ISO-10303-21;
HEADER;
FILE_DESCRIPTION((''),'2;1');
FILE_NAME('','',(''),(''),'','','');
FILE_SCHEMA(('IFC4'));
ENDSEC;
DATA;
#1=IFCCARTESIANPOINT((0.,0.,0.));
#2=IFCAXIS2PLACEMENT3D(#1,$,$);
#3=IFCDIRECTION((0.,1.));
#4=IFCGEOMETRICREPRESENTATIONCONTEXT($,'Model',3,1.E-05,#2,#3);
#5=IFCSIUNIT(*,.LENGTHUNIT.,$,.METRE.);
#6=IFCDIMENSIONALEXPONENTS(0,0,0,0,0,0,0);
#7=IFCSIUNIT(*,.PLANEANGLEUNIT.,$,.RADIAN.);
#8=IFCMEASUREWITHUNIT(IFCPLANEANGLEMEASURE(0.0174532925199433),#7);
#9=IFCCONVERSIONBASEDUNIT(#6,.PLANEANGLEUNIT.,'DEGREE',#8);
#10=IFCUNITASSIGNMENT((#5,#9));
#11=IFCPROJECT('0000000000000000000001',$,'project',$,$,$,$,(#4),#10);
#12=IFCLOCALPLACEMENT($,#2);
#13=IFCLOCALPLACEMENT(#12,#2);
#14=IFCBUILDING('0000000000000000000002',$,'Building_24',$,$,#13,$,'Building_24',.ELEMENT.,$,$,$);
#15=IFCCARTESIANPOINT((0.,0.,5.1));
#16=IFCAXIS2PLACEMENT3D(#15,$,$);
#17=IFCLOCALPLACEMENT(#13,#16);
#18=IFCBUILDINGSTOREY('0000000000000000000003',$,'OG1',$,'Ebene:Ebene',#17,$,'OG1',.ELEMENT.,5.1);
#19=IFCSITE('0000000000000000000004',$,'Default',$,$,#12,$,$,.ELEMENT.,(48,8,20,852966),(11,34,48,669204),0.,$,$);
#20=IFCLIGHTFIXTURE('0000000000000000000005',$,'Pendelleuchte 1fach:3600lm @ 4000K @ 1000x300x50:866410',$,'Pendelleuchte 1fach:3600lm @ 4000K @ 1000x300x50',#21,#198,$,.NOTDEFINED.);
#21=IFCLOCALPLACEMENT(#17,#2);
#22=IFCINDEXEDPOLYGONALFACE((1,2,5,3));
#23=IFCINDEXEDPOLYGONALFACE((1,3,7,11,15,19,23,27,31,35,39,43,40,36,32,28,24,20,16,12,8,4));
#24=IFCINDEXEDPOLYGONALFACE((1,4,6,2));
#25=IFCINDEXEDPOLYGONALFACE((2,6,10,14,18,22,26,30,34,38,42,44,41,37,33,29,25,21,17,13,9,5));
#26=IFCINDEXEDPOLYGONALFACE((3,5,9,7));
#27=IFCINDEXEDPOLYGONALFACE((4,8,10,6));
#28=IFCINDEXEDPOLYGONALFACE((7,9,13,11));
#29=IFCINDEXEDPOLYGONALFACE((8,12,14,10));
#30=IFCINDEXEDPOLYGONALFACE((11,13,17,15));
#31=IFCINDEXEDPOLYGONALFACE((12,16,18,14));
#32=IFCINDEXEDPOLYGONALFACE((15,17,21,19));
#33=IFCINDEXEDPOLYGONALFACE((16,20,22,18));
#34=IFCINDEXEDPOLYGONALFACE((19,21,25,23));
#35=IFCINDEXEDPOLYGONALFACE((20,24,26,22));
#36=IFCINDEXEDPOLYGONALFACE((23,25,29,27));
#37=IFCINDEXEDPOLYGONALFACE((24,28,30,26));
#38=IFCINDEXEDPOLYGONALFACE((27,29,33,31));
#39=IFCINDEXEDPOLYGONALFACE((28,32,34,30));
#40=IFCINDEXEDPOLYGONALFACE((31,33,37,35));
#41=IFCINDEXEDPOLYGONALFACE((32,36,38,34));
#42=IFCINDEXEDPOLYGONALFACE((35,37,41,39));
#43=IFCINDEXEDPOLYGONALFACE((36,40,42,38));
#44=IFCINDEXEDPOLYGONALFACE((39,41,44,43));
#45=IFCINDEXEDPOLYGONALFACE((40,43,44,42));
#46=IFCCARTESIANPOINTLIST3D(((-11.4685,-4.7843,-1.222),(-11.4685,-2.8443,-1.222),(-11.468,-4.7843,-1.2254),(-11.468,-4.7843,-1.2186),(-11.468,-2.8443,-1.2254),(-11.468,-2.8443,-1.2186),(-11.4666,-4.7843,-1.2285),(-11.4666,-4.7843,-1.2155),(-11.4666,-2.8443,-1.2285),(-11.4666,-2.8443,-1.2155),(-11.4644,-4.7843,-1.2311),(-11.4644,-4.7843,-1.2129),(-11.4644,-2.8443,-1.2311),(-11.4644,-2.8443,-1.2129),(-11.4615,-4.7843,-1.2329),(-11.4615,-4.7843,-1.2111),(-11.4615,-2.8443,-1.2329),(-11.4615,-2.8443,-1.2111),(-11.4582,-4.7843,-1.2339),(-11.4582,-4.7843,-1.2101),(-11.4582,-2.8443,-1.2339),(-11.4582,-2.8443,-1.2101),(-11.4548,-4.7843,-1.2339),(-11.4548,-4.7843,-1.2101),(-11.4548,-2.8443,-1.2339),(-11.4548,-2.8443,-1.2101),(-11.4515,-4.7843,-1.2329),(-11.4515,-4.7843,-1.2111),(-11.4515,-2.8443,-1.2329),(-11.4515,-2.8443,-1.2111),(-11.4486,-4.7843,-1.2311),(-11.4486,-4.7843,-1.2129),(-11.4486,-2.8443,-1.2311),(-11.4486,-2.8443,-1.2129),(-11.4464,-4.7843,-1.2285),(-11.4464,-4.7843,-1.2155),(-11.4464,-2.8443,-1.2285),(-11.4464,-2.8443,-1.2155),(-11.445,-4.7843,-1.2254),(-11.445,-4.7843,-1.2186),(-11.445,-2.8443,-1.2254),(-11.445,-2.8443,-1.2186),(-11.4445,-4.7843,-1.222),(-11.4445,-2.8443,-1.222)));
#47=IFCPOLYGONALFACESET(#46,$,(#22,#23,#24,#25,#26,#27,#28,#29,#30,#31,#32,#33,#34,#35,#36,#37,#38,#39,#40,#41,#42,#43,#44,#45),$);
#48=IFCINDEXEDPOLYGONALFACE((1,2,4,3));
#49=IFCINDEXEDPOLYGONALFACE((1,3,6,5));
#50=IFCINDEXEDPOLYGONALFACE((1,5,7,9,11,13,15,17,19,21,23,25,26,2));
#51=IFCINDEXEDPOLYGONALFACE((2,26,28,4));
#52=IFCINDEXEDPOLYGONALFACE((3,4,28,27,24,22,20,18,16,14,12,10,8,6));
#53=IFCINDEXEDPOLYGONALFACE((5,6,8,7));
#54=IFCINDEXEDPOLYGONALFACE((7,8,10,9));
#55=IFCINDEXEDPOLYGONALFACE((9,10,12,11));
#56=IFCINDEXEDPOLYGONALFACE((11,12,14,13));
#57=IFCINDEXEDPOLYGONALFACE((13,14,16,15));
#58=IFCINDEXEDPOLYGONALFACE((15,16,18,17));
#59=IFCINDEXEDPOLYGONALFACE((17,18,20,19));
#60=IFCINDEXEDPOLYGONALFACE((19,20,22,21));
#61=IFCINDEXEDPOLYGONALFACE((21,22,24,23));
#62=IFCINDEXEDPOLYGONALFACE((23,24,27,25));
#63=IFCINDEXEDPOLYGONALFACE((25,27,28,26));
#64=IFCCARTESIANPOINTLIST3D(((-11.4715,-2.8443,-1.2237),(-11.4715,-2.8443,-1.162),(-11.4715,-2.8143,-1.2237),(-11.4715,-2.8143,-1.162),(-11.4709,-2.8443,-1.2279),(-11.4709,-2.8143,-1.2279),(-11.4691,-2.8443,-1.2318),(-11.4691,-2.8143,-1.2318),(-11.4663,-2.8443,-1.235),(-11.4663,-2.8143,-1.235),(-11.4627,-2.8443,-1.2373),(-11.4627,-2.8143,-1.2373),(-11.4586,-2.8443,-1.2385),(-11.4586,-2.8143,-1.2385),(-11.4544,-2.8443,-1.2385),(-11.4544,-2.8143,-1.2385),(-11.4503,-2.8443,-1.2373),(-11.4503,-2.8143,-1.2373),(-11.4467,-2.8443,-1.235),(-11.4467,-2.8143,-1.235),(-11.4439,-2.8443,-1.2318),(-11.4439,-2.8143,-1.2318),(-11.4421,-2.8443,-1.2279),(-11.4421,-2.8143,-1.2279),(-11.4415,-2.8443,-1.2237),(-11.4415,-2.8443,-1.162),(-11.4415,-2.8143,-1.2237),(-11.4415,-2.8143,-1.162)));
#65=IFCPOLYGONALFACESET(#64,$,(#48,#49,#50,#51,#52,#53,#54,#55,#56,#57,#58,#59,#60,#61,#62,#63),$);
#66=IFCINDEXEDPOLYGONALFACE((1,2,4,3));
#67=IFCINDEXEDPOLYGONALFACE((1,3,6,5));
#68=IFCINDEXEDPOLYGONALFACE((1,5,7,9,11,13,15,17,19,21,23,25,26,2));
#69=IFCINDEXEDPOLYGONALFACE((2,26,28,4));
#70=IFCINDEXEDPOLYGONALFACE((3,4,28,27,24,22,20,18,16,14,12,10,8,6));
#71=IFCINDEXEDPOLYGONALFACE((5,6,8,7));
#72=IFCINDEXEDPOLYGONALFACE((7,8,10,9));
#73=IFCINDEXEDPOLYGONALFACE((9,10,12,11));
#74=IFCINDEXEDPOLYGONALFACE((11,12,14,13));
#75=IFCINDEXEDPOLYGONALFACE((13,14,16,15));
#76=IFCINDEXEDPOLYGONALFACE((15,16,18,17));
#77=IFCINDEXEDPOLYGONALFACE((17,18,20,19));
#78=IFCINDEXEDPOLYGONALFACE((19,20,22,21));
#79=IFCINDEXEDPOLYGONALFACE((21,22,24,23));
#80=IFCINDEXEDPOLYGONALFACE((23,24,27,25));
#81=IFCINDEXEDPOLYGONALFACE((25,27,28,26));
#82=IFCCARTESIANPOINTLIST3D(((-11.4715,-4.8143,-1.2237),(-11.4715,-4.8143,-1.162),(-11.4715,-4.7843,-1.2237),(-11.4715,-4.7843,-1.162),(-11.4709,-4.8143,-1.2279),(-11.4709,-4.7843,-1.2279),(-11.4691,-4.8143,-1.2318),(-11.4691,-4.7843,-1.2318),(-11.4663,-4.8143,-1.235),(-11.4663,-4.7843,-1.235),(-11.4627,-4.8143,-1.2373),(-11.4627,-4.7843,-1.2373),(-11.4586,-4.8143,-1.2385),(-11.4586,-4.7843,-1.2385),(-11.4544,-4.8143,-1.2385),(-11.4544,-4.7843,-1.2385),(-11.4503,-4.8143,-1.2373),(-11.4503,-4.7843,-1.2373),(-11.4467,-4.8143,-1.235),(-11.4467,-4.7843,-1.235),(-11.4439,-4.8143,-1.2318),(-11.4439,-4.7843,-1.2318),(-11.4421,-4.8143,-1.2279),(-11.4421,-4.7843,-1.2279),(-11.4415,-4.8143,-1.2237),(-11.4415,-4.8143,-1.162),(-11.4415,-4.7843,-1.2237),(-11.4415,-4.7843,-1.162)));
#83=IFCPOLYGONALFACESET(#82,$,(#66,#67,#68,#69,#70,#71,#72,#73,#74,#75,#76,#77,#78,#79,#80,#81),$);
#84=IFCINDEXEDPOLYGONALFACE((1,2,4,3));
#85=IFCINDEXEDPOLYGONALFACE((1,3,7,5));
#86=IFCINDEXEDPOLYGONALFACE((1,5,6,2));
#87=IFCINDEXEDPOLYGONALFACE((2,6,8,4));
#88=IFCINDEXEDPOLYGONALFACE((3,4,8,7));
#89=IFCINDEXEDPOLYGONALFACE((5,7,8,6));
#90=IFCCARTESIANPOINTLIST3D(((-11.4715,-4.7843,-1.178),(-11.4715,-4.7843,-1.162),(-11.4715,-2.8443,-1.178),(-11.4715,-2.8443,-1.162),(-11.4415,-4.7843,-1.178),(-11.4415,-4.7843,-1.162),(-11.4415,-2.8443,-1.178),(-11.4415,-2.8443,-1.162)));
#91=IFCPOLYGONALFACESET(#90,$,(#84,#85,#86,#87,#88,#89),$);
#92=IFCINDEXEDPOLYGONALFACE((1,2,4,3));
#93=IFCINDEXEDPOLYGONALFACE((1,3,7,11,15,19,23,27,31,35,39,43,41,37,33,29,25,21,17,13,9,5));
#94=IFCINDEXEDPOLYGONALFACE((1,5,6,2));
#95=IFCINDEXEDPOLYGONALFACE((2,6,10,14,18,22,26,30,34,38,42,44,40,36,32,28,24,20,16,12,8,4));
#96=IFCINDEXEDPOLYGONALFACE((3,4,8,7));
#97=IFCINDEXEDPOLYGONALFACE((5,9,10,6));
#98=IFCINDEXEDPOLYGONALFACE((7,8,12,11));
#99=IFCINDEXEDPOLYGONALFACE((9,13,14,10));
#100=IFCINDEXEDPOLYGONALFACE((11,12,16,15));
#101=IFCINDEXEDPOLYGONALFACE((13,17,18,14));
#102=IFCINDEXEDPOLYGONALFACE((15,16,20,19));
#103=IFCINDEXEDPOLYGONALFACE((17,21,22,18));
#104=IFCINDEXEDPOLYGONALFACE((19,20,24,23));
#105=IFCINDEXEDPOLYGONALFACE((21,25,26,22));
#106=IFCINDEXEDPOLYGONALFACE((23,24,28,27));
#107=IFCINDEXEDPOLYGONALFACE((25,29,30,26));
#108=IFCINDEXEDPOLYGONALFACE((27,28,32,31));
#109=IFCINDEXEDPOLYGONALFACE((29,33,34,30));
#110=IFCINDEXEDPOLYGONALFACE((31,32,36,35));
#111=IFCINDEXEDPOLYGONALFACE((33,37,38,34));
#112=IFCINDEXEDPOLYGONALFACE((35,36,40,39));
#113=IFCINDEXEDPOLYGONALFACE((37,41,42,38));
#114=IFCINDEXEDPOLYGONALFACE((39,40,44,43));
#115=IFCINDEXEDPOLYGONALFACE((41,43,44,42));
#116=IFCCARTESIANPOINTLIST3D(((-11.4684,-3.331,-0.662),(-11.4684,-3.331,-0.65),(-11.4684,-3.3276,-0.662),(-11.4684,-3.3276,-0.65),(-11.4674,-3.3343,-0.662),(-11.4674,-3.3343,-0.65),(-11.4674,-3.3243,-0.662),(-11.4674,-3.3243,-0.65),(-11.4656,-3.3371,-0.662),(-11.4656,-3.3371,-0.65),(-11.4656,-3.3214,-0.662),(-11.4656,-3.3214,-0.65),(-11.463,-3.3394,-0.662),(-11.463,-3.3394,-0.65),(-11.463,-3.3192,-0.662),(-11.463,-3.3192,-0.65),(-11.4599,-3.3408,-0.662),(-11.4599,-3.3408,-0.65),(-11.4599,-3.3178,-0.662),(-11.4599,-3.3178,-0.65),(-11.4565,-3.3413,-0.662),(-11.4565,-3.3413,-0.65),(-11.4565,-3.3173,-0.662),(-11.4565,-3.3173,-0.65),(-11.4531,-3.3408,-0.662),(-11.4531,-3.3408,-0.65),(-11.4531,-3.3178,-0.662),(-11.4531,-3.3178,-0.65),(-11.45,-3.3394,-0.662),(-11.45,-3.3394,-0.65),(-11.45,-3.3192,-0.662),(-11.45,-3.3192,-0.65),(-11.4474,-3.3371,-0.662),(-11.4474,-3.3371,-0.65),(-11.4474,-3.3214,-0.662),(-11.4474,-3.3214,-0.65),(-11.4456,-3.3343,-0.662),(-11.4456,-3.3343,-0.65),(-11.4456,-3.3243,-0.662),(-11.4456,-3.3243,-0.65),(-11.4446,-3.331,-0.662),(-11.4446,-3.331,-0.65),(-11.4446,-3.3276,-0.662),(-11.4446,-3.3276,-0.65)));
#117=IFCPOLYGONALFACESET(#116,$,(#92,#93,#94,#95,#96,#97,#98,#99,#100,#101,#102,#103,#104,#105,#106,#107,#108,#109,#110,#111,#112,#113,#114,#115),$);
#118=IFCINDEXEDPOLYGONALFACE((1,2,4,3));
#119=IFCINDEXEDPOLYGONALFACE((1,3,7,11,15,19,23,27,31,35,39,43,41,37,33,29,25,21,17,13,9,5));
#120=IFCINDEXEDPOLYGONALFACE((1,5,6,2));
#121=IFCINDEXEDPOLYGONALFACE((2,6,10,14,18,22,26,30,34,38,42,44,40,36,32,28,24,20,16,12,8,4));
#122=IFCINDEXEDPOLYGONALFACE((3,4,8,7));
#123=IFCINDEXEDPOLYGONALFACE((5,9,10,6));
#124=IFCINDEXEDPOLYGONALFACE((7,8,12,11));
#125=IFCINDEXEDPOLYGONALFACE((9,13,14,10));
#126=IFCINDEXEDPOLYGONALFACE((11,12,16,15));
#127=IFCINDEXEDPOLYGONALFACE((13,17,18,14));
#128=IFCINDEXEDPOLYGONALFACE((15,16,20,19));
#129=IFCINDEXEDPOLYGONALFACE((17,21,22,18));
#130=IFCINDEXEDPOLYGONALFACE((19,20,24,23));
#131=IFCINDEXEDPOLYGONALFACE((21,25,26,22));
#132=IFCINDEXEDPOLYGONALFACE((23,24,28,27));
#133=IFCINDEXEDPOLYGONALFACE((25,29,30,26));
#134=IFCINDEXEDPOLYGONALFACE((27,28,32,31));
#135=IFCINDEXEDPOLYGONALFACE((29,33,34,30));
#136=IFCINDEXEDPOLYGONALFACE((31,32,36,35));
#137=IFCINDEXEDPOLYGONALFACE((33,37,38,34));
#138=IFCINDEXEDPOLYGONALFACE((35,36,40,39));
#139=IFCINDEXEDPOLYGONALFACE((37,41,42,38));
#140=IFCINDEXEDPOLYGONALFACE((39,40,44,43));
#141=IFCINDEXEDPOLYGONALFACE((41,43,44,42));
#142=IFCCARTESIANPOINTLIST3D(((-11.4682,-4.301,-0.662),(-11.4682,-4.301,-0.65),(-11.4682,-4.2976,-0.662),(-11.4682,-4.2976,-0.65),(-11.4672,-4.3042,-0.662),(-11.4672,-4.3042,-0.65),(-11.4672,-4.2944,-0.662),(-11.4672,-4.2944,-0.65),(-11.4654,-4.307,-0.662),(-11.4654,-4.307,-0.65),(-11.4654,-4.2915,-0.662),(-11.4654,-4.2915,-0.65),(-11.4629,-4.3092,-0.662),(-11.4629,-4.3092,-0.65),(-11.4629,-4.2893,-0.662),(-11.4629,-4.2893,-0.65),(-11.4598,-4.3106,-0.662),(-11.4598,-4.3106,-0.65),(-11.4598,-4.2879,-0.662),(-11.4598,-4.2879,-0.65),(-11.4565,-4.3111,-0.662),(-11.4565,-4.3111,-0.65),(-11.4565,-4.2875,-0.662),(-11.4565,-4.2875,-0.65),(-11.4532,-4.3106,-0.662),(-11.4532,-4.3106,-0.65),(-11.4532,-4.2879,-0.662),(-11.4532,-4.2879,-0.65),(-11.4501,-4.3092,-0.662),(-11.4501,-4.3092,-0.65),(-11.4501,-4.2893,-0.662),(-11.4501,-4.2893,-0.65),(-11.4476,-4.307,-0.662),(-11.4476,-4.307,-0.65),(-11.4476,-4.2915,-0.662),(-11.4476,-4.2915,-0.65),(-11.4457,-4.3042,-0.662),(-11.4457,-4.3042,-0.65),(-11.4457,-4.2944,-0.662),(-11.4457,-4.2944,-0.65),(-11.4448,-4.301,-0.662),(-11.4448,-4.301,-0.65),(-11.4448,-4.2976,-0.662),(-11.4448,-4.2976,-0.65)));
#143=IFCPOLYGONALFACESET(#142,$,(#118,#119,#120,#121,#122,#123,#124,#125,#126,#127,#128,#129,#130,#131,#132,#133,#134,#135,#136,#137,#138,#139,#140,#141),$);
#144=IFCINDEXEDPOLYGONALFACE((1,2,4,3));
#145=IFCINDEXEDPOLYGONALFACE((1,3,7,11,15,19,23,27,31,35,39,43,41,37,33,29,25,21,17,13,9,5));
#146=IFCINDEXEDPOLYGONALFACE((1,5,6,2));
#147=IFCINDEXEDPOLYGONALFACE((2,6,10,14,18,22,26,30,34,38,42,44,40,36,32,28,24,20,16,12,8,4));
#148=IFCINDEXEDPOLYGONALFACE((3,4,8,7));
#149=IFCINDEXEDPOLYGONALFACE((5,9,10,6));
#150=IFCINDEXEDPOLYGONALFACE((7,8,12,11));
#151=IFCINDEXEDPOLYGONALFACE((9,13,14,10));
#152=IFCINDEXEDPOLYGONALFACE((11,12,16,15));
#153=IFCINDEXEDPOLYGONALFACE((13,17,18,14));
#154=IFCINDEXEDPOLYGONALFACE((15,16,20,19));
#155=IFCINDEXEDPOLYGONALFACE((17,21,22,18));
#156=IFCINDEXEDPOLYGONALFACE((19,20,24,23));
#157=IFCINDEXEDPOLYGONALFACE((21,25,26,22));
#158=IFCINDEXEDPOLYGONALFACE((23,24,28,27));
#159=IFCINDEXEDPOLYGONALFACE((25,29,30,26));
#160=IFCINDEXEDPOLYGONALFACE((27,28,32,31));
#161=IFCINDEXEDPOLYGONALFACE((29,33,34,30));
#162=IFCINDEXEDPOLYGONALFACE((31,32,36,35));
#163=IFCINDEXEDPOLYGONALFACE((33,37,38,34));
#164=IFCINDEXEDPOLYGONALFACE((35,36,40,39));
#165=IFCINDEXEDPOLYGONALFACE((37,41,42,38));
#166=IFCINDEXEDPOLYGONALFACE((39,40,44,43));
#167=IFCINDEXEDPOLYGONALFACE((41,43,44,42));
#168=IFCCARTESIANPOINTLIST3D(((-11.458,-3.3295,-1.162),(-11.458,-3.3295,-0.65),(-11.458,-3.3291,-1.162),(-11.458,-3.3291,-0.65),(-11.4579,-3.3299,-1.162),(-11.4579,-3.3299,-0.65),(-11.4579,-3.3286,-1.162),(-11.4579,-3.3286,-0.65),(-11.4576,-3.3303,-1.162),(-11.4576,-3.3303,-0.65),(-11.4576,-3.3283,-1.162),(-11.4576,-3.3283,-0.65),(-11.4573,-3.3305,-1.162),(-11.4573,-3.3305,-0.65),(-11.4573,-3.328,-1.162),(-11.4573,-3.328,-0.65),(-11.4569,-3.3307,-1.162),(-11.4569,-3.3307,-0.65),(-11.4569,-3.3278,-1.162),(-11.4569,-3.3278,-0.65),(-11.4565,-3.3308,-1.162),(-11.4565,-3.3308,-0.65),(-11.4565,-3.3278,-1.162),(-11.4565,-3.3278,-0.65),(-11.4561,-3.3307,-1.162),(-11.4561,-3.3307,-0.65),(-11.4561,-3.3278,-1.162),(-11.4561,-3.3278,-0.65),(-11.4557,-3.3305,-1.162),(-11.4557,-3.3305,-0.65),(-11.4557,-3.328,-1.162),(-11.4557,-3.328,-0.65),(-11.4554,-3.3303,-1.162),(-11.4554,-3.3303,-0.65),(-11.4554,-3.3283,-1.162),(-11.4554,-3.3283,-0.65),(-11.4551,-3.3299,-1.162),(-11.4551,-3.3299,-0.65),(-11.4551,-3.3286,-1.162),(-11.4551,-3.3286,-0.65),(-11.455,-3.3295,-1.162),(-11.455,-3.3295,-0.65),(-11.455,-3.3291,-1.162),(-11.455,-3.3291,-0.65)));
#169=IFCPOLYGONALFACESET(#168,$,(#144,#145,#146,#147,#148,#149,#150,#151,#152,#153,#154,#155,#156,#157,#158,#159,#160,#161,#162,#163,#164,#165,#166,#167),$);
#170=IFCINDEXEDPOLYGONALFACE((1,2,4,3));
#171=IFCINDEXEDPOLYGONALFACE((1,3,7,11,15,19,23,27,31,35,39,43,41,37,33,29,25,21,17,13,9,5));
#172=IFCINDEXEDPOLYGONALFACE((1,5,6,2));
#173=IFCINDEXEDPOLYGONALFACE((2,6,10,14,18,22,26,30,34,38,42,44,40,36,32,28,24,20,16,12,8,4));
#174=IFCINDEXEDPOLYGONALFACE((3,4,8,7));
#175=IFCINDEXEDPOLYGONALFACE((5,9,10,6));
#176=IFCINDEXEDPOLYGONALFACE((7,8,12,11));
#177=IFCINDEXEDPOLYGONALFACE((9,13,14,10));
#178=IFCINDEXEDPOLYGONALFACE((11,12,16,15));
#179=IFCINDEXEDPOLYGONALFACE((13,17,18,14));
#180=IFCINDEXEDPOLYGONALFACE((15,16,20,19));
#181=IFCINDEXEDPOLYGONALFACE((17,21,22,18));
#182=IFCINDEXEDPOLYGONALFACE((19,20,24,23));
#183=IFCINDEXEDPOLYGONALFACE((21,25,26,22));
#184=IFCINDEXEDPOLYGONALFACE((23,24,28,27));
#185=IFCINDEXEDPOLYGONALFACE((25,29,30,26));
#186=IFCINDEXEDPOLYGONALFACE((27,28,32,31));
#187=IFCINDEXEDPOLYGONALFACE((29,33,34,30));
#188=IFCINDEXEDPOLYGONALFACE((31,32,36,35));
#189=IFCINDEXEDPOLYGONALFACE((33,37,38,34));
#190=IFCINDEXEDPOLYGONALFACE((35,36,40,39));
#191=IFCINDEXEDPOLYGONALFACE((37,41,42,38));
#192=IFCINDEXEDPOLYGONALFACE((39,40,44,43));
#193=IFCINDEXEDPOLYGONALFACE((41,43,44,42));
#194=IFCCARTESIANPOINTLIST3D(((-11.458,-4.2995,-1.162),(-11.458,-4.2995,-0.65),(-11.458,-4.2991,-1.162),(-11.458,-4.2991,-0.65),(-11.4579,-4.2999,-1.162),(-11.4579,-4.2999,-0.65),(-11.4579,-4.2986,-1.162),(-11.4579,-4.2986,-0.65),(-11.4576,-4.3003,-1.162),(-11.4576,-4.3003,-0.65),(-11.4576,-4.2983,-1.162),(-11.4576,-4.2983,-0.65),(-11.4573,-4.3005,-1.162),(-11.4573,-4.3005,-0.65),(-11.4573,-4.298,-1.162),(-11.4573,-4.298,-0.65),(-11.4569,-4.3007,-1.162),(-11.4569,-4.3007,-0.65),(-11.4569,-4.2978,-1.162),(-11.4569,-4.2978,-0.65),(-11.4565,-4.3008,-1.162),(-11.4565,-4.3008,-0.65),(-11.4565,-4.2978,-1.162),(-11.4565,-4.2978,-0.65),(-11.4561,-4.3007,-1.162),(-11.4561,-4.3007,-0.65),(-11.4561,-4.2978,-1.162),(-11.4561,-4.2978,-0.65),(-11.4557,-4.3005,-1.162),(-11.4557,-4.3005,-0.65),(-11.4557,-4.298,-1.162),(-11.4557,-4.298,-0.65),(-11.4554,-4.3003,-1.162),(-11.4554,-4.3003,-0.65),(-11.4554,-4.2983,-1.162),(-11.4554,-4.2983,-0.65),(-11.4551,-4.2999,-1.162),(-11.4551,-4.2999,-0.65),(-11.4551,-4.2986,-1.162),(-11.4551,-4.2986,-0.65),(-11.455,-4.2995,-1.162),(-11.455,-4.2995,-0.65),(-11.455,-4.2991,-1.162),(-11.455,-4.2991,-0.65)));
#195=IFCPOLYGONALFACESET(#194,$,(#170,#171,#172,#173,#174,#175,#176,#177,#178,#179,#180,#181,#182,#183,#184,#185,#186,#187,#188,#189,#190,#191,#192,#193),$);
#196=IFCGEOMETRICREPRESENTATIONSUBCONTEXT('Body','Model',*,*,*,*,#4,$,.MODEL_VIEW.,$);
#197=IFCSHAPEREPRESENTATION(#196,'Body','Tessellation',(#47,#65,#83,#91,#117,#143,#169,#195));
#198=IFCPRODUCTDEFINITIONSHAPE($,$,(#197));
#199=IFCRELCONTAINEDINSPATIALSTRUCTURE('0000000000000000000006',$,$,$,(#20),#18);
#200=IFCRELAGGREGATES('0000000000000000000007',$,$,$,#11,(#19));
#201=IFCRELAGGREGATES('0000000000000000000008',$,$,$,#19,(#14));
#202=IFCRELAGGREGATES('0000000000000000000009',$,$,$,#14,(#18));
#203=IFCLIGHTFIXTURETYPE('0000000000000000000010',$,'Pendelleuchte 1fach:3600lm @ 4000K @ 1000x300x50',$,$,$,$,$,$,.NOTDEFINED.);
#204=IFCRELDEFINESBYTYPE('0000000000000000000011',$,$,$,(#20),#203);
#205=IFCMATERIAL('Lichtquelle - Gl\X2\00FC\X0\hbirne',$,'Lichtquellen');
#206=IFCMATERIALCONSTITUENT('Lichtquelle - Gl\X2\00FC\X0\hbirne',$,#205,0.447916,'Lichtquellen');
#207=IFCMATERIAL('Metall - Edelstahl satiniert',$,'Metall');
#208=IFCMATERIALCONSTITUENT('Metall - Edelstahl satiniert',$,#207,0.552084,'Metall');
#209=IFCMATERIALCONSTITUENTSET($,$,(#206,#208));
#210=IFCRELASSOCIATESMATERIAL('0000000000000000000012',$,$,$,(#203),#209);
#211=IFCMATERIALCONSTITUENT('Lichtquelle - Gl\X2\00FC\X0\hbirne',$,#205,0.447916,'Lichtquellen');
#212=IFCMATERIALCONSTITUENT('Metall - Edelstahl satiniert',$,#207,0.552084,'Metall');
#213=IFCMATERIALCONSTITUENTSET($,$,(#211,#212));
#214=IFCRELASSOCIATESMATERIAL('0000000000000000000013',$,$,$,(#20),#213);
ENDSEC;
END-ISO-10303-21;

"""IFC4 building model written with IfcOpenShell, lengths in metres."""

from ifc_helpers import new_model, entity, si_unit, converted_unit, direction, frame, origin, place, context, subcontext, project, spatial, line, arc, indexed_curve, outline, extrude, source, transform, mapped, material, constituent, constituent_set, type_object, type_shapes, element, save


model = new_model("IFC4")

# Units and contexts
model_context = context("Model", 3, precision=1e-05, world=origin(), true_north=direction((0.0, 1.0)))
body_context = subcontext(model_context, "Body", "Model", "MODEL_VIEW")
ifc_project = project(units=[si_unit("LENGTHUNIT", "METRE"), converted_unit("PLANEANGLEUNIT", "DEGREE", entity("IfcPlaneAngleMeasure", 0.0174532925199433), si_unit("PLANEANGLEUNIT", "RADIAN"), dimensions=[0, 0, 0, 0, 0, 0, 0])], contexts=[model_context])

# Site, building, storey
site_placement = place(None, origin())
site = spatial("IfcSite", under=ifc_project, at=site_placement, Name="Default", CompositionType="ELEMENT", RefLatitude=(48, 8, 20, 852966), RefLongitude=(11, 34, 48, 669204), RefElevation=0.0)
building_placement = place(site_placement, origin())
building = spatial("IfcBuilding", under=site, at=building_placement, Name="Building_24", LongName="Building_24", CompositionType="ELEMENT")
storey_placement = place(building_placement, frame((0.0, 0.0, 5.1)))
storey = spatial("IfcBuildingStorey", under=building, at=storey_placement, Name="OG1", ObjectType="Ebene:Ebene", LongName="OG1", CompositionType="ELEMENT", Elevation=5.1)

# Light fixture
ifc_material_1 = material(Name="Lichtquelle - Glühbirne", Category="Lichtquellen")
ifc_material_2 = material(Name="Metall - Edelstahl satiniert", Category="Metall")
ifc_constituent_1 = constituent(ifc_material_1, Name="Lichtquelle - Glühbirne", Category="Lichtquellen", fraction=0.447916)
ifc_constituent_2 = constituent(ifc_material_2, Name="Metall - Edelstahl satiniert", Category="Metall", fraction=0.552084)
ifc_constituent_set_1 = constituent_set(constituents=[ifc_constituent_1, ifc_constituent_2])
light_fixture_type_1 = type_object("IfcLightFixtureType", Name="Pendelleuchte 1fach:3600lm @ 4000K @ 1000x300x50", PredefinedType="NOTDEFINED", material=ifc_constituent_set_1)
shared_shape_1 = source(origin(), body_context, "Body", "SweptSolid", [
    extrude(outline(indexed_curve([(-0.012, 0.0), (0.0, -0.012), (0.012, 0.0), (0.0, 0.012)], segments=[arc(1, 2, 3), arc(3, 4, 1)], self_intersect=False)), frame((-0.97, 0.0, -0.572), z_axis=(1.0, 0.0, 0.0), x_axis=(0.0, 1.0, 0.0)), (0.0, 0.0, 1.0), 1.94),
    extrude(outline(indexed_curve([(-0.0308, -0.015), (0.0308, -0.015), (0.0308, 0.015), (-0.0308, 0.015), (-0.0458, 0.0)], segments=[line(1, 2, 3, 4), arc(4, 5, 1)], self_intersect=False)), frame((0.97, 0.0, -0.5428), z_axis=(1.0, 0.0, 0.0), x_axis=(0.0, 0.0, 1.0)), (0.0, 0.0, 1.0), 0.03),
    extrude(outline(indexed_curve([(-0.0308, -0.015), (0.0308, -0.015), (0.0308, 0.015), (-0.0308, 0.015), (-0.0458, 0.0)], segments=[line(1, 2, 3, 4), arc(4, 5, 1)], self_intersect=False)), frame((-1.0, 0.0, -0.5428), z_axis=(1.0, 0.0, 0.0), x_axis=(0.0, 0.0, 1.0)), (0.0, 0.0, 1.0), 0.03),
    extrude(outline(indexed_curve([(-0.97, -0.015), (0.97, -0.015), (0.97, 0.015), (-0.97, 0.015), (-0.97, -0.015)], self_intersect=False)), frame((0.0, 0.0, -0.528), z_axis=(0.0, 0.0, 1.0), x_axis=(-1.0, 0.0, 0.0)), (0.0, 0.0, 1.0), 0.016),
    extrude(outline(indexed_curve([(-0.012, 0.0), (0.0, -0.012), (0.012, 0.0), (0.0, 0.012)], segments=[arc(1, 2, 3), arc(3, 4, 1)], self_intersect=False)), frame((0.485, 0.0, -0.012)), (0.0, 0.0, 1.0), 0.012),
    extrude(outline(indexed_curve([(-0.0118, 0.0), (0.0, -0.0118), (0.0118, 0.0), (0.0, 0.0118)], segments=[arc(1, 2, 3), arc(3, 4, 1)], self_intersect=False)), frame((-0.485, 0.0, -0.012)), (0.0, 0.0, 1.0), 0.012),
    extrude(outline(indexed_curve([(-0.0015, 0.0), (0.0, -0.0015), (0.0015, 0.0), (0.0, 0.0015)], segments=[arc(1, 2, 3), arc(3, 4, 1)], self_intersect=False)), frame((0.485, 0.0, -0.512)), (0.0, 0.0, 1.0), 0.512),
    extrude(outline(indexed_curve([(-0.0015, 0.0), (0.0, -0.0015), (0.0015, 0.0), (0.0, 0.0015)], segments=[arc(1, 2, 3), arc(3, 4, 1)], self_intersect=False)), frame((-0.485, 0.0, -0.512)), (0.0, 0.0, 1.0), 0.512),
])
type_shapes(light_fixture_type_1, [shared_shape_1])
ifc_constituent_3 = constituent(ifc_material_1, Name="Lichtquelle - Glühbirne", Category="Lichtquellen", fraction=0.447916)
ifc_constituent_4 = constituent(ifc_material_2, Name="Metall - Edelstahl satiniert", Category="Metall", fraction=0.552084)
ifc_constituent_set_2 = constituent_set(constituents=[ifc_constituent_3, ifc_constituent_4])
light_fixture_1_placement = place(storey_placement, frame((-11.4565, -3.8143, -0.65), z_axis=(0.0, 0.0, 1.0), x_axis=(0.0, 1.0, 0.0)))
element("IfcLightFixture", 1, at=light_fixture_1_placement, inside=storey, type_object=light_fixture_type_1, material=ifc_constituent_set_2, Name="Pendelleuchte 1fach:3600lm @ 4000K @ 1000x300x50:866410", ObjectType="Pendelleuchte 1fach:3600lm @ 4000K @ 1000x300x50", PredefinedType="NOTDEFINED", context=body_context, shape_type="MappedRepresentation", body=[
    mapped(shared_shape_1, transform((0.0, 0.0, 0.0), scale=1.0)),
])

save(model, "model.ifc")
